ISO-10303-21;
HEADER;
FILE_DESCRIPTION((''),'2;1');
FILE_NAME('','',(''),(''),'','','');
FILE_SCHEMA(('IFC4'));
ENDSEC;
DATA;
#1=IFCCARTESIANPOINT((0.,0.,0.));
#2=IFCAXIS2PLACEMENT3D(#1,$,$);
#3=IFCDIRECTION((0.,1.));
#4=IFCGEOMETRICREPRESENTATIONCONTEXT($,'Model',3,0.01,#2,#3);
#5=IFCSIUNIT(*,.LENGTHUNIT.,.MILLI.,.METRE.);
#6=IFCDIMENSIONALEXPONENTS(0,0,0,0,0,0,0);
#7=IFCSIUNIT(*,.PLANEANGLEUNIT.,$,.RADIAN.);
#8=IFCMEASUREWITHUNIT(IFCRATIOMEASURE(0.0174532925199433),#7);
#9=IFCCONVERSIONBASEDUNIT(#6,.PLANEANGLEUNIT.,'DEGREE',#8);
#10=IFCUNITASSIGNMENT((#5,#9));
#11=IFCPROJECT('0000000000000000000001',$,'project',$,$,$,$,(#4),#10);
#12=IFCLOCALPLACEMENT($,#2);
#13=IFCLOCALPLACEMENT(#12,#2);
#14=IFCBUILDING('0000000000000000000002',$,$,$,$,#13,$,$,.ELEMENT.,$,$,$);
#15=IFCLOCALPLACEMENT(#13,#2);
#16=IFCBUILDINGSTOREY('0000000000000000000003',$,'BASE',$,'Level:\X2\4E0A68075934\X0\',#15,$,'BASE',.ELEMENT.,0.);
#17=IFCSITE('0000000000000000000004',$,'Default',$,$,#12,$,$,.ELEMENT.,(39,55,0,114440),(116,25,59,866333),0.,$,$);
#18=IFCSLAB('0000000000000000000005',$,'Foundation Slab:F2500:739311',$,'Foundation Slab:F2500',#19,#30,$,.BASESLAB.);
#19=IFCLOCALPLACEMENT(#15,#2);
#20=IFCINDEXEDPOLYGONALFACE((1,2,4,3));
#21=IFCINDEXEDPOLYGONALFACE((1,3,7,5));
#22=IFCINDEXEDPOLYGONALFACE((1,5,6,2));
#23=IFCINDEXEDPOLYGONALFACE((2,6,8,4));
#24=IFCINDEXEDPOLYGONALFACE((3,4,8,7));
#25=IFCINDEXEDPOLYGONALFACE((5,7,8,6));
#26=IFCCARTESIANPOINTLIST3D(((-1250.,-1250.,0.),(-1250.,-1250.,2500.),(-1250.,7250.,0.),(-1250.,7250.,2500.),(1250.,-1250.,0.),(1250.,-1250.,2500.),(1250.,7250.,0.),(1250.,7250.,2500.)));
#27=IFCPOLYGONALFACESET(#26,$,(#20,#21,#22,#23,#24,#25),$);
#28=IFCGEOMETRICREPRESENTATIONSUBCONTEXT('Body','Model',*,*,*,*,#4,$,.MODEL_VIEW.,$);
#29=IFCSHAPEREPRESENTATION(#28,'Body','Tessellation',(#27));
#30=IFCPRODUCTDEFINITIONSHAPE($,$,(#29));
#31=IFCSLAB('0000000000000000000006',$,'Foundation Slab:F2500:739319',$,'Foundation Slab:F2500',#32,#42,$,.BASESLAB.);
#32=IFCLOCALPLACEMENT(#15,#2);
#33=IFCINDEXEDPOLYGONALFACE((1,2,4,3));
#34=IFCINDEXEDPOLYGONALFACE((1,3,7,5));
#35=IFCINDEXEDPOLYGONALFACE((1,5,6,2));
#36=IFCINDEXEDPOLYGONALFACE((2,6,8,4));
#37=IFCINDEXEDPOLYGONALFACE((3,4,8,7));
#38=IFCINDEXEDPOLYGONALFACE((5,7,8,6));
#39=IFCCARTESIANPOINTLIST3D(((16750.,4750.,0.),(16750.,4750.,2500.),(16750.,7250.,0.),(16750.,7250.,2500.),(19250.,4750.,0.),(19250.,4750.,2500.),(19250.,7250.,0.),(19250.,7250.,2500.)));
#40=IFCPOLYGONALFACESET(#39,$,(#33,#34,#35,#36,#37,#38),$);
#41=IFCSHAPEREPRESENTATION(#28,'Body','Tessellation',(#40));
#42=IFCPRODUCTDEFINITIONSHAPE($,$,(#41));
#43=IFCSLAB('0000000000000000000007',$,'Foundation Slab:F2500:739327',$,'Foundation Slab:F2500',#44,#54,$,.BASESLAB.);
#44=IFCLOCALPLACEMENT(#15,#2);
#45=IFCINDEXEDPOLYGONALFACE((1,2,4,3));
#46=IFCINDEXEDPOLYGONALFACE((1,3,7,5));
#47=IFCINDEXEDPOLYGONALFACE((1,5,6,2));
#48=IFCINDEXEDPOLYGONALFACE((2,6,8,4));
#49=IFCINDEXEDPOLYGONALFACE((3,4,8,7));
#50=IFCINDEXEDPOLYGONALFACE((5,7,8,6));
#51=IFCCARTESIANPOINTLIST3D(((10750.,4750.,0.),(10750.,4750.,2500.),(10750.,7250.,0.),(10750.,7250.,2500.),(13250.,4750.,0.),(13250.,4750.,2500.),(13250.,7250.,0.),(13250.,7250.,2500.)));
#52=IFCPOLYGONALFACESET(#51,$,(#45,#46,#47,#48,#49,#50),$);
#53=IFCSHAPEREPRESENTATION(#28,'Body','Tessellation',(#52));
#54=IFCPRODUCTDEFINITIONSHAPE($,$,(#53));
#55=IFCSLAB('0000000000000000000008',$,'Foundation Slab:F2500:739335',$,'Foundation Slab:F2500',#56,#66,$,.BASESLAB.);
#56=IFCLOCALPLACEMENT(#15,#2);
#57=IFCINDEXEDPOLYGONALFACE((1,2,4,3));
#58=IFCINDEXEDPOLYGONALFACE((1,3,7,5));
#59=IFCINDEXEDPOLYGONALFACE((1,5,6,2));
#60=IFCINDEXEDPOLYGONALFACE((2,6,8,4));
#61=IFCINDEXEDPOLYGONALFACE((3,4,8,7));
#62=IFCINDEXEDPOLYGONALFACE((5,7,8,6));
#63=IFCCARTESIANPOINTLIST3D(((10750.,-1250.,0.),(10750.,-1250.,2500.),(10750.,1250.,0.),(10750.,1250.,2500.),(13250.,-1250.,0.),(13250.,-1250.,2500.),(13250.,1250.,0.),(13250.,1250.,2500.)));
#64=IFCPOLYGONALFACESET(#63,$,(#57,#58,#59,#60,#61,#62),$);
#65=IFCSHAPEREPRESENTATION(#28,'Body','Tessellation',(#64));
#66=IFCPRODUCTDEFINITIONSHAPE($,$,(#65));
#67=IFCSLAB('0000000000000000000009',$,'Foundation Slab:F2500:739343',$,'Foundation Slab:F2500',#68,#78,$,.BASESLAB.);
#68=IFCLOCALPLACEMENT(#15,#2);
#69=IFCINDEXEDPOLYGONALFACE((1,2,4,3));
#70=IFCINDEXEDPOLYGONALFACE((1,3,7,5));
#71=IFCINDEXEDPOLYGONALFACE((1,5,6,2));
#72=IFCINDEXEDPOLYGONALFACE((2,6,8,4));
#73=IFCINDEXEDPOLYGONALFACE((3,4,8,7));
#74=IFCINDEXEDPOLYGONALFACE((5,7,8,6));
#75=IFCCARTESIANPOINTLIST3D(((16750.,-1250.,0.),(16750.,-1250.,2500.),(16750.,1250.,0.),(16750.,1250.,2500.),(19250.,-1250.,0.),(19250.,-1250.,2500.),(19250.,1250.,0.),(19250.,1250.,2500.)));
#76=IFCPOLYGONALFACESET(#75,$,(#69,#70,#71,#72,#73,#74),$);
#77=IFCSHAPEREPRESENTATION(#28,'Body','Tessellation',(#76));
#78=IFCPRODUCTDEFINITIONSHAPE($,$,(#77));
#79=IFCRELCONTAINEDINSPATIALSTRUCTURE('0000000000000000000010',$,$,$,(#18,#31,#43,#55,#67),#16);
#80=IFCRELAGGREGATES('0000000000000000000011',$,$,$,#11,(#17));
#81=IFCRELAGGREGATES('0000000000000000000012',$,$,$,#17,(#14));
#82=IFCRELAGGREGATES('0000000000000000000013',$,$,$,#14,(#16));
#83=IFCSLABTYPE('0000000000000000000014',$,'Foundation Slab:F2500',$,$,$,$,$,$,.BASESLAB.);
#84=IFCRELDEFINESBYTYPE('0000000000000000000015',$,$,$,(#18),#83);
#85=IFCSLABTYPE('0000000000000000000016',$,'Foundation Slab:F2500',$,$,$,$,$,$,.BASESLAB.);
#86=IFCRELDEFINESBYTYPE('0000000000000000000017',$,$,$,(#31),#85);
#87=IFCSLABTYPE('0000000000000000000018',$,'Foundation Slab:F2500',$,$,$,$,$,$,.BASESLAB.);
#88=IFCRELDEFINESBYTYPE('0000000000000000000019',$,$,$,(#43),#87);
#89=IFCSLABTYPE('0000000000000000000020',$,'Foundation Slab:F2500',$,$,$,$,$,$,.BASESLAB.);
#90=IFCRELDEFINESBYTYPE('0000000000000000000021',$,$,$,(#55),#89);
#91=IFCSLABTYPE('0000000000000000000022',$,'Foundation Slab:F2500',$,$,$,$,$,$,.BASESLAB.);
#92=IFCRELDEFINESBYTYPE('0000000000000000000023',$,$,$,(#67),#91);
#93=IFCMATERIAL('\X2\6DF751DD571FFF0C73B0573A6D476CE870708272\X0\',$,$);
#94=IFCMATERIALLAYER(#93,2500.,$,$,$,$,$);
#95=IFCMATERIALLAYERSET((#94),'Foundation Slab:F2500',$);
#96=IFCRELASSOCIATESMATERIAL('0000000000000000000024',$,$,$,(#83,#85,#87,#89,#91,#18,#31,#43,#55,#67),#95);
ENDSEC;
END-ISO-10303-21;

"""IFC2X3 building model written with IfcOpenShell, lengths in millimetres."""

from ifc_helpers import new_model, entity, si_unit, converted_unit, direction, frame, origin, origin_2d_with_axis, place, context, subcontext, project, spatial, rectangle, extrude, material, layer, layer_set, layer_usage, type_object, element, save


model = new_model("IFC2X3")

# Units and contexts
model_context = context("Model", 3, precision=0.01, world=origin(), true_north=direction((0.0, 1.0)))
body_context = subcontext(model_context, "Body", "Model", "MODEL_VIEW")
ifc_project = project(units=[si_unit("LENGTHUNIT", "METRE", prefix="MILLI"), converted_unit("PLANEANGLEUNIT", "DEGREE", entity("IfcRatioMeasure", 0.0174532925199433), si_unit("PLANEANGLEUNIT", "RADIAN"), dimensions=[0, 0, 0, 0, 0, 0, 0])], contexts=[model_context])

# Site, building, storey
site_placement = place(None, origin())
site = spatial("IfcSite", under=ifc_project, at=site_placement, Name="Default", CompositionType="ELEMENT", RefLatitude=(39, 55, 0, 114440), RefLongitude=(116, 25, 59, 866333), RefElevation=0.0)
building_placement = place(site_placement, origin())
building = spatial("IfcBuilding", under=site, at=building_placement, CompositionType="ELEMENT")
storey_placement = place(building_placement, origin())
storey = spatial("IfcBuildingStorey", under=building, at=storey_placement, Name="BASE", ObjectType="Level:上标头", LongName="BASE", CompositionType="ELEMENT", Elevation=0.0)

# Slabs
ifc_material = material(Name="混凝土，现场浇注灰色")
ifc_layer = layer(ifc_material, 2500.0)
ifc_layer_set = layer_set([ifc_layer], Name="Foundation Slab:F2500")
ifc_layer_usage_1 = layer_usage(ifc_layer_set, "AXIS3", "POSITIVE", 0.0)
slab_type_1 = type_object("IfcSlabType", Name="Foundation Slab:F2500", PredefinedType="BASESLAB", material=ifc_layer_set)
slab_1_placement = place(storey_placement, origin())
element("IfcSlab", 1, at=slab_1_placement, inside=storey, type_object=slab_type_1, material=ifc_layer_usage_1, Name="Foundation Slab:F2500:739311", ObjectType="Foundation Slab:F2500", PredefinedType="BASESLAB", context=body_context, shape_type="SweptSolid", body=[
    extrude(rectangle(XDim=8500.0, YDim=2500.0, at=origin_2d_with_axis()), frame((0.0, 3000.0, 2500.0), z_axis=(0.0, 0.0, -1.0), x_axis=(0.0, 1.0, 0.0)), (0.0, 0.0, 1.0), 2500.0),
])
ifc_layer_usage_2 = layer_usage(ifc_layer_set, "AXIS3", "POSITIVE", 0.0)
slab_type_2 = type_object("IfcSlabType", Name="Foundation Slab:F2500", PredefinedType="BASESLAB", material=ifc_layer_set)
slab_2_placement = place(storey_placement, origin())
element("IfcSlab", 2, at=slab_2_placement, inside=storey, type_object=slab_type_2, material=ifc_layer_usage_2, Name="Foundation Slab:F2500:739319", ObjectType="Foundation Slab:F2500", PredefinedType="BASESLAB", context=body_context, shape_type="SweptSolid", body=[
    extrude(rectangle(XDim=2500.0, YDim=2500.0, at=origin_2d_with_axis()), frame((18000.0, 6000.0, 2500.0), z_axis=(0.0, 0.0, -1.0), x_axis=(0.0, 1.0, 0.0)), (0.0, 0.0, 1.0), 2500.0),
])
ifc_layer_usage_3 = layer_usage(ifc_layer_set, "AXIS3", "POSITIVE", 0.0)
slab_type_3 = type_object("IfcSlabType", Name="Foundation Slab:F2500", PredefinedType="BASESLAB", material=ifc_layer_set)
slab_3_placement = place(storey_placement, origin())
element("IfcSlab", 3, at=slab_3_placement, inside=storey, type_object=slab_type_3, material=ifc_layer_usage_3, Name="Foundation Slab:F2500:739327", ObjectType="Foundation Slab:F2500", PredefinedType="BASESLAB", context=body_context, shape_type="SweptSolid", body=[
    extrude(rectangle(XDim=2500.0, YDim=2500.0, at=origin_2d_with_axis()), frame((12000.0, 6000.0, 2500.0), z_axis=(0.0, 0.0, -1.0), x_axis=(0.0, 1.0, 0.0)), (0.0, 0.0, 1.0), 2500.0),
])
ifc_layer_usage_4 = layer_usage(ifc_layer_set, "AXIS3", "POSITIVE", 0.0)
slab_type_4 = type_object("IfcSlabType", Name="Foundation Slab:F2500", PredefinedType="BASESLAB", material=ifc_layer_set)
slab_4_placement = place(storey_placement, origin())
element("IfcSlab", 4, at=slab_4_placement, inside=storey, type_object=slab_type_4, material=ifc_layer_usage_4, Name="Foundation Slab:F2500:739335", ObjectType="Foundation Slab:F2500", PredefinedType="BASESLAB", context=body_context, shape_type="SweptSolid", body=[
    extrude(rectangle(XDim=2500.0, YDim=2500.0, at=origin_2d_with_axis()), frame((12000.0, 0.0, 2500.0), z_axis=(0.0, 0.0, -1.0), x_axis=(0.0, 1.0, 0.0)), (0.0, 0.0, 1.0), 2500.0),
])
ifc_layer_usage_5 = layer_usage(ifc_layer_set, "AXIS3", "POSITIVE", 0.0)
slab_type_5 = type_object("IfcSlabType", Name="Foundation Slab:F2500", PredefinedType="BASESLAB", material=ifc_layer_set)
slab_5_placement = place(storey_placement, origin())
element("IfcSlab", 5, at=slab_5_placement, inside=storey, type_object=slab_type_5, material=ifc_layer_usage_5, Name="Foundation Slab:F2500:739343", ObjectType="Foundation Slab:F2500", PredefinedType="BASESLAB", context=body_context, shape_type="SweptSolid", body=[
    extrude(rectangle(XDim=2500.0, YDim=2500.0, at=origin_2d_with_axis()), frame((18000.0, 0.0, 2500.0), z_axis=(0.0, 0.0, -1.0), x_axis=(0.0, 1.0, 0.0)), (0.0, 0.0, 1.0), 2500.0),
])

save(model, "model.ifc")
